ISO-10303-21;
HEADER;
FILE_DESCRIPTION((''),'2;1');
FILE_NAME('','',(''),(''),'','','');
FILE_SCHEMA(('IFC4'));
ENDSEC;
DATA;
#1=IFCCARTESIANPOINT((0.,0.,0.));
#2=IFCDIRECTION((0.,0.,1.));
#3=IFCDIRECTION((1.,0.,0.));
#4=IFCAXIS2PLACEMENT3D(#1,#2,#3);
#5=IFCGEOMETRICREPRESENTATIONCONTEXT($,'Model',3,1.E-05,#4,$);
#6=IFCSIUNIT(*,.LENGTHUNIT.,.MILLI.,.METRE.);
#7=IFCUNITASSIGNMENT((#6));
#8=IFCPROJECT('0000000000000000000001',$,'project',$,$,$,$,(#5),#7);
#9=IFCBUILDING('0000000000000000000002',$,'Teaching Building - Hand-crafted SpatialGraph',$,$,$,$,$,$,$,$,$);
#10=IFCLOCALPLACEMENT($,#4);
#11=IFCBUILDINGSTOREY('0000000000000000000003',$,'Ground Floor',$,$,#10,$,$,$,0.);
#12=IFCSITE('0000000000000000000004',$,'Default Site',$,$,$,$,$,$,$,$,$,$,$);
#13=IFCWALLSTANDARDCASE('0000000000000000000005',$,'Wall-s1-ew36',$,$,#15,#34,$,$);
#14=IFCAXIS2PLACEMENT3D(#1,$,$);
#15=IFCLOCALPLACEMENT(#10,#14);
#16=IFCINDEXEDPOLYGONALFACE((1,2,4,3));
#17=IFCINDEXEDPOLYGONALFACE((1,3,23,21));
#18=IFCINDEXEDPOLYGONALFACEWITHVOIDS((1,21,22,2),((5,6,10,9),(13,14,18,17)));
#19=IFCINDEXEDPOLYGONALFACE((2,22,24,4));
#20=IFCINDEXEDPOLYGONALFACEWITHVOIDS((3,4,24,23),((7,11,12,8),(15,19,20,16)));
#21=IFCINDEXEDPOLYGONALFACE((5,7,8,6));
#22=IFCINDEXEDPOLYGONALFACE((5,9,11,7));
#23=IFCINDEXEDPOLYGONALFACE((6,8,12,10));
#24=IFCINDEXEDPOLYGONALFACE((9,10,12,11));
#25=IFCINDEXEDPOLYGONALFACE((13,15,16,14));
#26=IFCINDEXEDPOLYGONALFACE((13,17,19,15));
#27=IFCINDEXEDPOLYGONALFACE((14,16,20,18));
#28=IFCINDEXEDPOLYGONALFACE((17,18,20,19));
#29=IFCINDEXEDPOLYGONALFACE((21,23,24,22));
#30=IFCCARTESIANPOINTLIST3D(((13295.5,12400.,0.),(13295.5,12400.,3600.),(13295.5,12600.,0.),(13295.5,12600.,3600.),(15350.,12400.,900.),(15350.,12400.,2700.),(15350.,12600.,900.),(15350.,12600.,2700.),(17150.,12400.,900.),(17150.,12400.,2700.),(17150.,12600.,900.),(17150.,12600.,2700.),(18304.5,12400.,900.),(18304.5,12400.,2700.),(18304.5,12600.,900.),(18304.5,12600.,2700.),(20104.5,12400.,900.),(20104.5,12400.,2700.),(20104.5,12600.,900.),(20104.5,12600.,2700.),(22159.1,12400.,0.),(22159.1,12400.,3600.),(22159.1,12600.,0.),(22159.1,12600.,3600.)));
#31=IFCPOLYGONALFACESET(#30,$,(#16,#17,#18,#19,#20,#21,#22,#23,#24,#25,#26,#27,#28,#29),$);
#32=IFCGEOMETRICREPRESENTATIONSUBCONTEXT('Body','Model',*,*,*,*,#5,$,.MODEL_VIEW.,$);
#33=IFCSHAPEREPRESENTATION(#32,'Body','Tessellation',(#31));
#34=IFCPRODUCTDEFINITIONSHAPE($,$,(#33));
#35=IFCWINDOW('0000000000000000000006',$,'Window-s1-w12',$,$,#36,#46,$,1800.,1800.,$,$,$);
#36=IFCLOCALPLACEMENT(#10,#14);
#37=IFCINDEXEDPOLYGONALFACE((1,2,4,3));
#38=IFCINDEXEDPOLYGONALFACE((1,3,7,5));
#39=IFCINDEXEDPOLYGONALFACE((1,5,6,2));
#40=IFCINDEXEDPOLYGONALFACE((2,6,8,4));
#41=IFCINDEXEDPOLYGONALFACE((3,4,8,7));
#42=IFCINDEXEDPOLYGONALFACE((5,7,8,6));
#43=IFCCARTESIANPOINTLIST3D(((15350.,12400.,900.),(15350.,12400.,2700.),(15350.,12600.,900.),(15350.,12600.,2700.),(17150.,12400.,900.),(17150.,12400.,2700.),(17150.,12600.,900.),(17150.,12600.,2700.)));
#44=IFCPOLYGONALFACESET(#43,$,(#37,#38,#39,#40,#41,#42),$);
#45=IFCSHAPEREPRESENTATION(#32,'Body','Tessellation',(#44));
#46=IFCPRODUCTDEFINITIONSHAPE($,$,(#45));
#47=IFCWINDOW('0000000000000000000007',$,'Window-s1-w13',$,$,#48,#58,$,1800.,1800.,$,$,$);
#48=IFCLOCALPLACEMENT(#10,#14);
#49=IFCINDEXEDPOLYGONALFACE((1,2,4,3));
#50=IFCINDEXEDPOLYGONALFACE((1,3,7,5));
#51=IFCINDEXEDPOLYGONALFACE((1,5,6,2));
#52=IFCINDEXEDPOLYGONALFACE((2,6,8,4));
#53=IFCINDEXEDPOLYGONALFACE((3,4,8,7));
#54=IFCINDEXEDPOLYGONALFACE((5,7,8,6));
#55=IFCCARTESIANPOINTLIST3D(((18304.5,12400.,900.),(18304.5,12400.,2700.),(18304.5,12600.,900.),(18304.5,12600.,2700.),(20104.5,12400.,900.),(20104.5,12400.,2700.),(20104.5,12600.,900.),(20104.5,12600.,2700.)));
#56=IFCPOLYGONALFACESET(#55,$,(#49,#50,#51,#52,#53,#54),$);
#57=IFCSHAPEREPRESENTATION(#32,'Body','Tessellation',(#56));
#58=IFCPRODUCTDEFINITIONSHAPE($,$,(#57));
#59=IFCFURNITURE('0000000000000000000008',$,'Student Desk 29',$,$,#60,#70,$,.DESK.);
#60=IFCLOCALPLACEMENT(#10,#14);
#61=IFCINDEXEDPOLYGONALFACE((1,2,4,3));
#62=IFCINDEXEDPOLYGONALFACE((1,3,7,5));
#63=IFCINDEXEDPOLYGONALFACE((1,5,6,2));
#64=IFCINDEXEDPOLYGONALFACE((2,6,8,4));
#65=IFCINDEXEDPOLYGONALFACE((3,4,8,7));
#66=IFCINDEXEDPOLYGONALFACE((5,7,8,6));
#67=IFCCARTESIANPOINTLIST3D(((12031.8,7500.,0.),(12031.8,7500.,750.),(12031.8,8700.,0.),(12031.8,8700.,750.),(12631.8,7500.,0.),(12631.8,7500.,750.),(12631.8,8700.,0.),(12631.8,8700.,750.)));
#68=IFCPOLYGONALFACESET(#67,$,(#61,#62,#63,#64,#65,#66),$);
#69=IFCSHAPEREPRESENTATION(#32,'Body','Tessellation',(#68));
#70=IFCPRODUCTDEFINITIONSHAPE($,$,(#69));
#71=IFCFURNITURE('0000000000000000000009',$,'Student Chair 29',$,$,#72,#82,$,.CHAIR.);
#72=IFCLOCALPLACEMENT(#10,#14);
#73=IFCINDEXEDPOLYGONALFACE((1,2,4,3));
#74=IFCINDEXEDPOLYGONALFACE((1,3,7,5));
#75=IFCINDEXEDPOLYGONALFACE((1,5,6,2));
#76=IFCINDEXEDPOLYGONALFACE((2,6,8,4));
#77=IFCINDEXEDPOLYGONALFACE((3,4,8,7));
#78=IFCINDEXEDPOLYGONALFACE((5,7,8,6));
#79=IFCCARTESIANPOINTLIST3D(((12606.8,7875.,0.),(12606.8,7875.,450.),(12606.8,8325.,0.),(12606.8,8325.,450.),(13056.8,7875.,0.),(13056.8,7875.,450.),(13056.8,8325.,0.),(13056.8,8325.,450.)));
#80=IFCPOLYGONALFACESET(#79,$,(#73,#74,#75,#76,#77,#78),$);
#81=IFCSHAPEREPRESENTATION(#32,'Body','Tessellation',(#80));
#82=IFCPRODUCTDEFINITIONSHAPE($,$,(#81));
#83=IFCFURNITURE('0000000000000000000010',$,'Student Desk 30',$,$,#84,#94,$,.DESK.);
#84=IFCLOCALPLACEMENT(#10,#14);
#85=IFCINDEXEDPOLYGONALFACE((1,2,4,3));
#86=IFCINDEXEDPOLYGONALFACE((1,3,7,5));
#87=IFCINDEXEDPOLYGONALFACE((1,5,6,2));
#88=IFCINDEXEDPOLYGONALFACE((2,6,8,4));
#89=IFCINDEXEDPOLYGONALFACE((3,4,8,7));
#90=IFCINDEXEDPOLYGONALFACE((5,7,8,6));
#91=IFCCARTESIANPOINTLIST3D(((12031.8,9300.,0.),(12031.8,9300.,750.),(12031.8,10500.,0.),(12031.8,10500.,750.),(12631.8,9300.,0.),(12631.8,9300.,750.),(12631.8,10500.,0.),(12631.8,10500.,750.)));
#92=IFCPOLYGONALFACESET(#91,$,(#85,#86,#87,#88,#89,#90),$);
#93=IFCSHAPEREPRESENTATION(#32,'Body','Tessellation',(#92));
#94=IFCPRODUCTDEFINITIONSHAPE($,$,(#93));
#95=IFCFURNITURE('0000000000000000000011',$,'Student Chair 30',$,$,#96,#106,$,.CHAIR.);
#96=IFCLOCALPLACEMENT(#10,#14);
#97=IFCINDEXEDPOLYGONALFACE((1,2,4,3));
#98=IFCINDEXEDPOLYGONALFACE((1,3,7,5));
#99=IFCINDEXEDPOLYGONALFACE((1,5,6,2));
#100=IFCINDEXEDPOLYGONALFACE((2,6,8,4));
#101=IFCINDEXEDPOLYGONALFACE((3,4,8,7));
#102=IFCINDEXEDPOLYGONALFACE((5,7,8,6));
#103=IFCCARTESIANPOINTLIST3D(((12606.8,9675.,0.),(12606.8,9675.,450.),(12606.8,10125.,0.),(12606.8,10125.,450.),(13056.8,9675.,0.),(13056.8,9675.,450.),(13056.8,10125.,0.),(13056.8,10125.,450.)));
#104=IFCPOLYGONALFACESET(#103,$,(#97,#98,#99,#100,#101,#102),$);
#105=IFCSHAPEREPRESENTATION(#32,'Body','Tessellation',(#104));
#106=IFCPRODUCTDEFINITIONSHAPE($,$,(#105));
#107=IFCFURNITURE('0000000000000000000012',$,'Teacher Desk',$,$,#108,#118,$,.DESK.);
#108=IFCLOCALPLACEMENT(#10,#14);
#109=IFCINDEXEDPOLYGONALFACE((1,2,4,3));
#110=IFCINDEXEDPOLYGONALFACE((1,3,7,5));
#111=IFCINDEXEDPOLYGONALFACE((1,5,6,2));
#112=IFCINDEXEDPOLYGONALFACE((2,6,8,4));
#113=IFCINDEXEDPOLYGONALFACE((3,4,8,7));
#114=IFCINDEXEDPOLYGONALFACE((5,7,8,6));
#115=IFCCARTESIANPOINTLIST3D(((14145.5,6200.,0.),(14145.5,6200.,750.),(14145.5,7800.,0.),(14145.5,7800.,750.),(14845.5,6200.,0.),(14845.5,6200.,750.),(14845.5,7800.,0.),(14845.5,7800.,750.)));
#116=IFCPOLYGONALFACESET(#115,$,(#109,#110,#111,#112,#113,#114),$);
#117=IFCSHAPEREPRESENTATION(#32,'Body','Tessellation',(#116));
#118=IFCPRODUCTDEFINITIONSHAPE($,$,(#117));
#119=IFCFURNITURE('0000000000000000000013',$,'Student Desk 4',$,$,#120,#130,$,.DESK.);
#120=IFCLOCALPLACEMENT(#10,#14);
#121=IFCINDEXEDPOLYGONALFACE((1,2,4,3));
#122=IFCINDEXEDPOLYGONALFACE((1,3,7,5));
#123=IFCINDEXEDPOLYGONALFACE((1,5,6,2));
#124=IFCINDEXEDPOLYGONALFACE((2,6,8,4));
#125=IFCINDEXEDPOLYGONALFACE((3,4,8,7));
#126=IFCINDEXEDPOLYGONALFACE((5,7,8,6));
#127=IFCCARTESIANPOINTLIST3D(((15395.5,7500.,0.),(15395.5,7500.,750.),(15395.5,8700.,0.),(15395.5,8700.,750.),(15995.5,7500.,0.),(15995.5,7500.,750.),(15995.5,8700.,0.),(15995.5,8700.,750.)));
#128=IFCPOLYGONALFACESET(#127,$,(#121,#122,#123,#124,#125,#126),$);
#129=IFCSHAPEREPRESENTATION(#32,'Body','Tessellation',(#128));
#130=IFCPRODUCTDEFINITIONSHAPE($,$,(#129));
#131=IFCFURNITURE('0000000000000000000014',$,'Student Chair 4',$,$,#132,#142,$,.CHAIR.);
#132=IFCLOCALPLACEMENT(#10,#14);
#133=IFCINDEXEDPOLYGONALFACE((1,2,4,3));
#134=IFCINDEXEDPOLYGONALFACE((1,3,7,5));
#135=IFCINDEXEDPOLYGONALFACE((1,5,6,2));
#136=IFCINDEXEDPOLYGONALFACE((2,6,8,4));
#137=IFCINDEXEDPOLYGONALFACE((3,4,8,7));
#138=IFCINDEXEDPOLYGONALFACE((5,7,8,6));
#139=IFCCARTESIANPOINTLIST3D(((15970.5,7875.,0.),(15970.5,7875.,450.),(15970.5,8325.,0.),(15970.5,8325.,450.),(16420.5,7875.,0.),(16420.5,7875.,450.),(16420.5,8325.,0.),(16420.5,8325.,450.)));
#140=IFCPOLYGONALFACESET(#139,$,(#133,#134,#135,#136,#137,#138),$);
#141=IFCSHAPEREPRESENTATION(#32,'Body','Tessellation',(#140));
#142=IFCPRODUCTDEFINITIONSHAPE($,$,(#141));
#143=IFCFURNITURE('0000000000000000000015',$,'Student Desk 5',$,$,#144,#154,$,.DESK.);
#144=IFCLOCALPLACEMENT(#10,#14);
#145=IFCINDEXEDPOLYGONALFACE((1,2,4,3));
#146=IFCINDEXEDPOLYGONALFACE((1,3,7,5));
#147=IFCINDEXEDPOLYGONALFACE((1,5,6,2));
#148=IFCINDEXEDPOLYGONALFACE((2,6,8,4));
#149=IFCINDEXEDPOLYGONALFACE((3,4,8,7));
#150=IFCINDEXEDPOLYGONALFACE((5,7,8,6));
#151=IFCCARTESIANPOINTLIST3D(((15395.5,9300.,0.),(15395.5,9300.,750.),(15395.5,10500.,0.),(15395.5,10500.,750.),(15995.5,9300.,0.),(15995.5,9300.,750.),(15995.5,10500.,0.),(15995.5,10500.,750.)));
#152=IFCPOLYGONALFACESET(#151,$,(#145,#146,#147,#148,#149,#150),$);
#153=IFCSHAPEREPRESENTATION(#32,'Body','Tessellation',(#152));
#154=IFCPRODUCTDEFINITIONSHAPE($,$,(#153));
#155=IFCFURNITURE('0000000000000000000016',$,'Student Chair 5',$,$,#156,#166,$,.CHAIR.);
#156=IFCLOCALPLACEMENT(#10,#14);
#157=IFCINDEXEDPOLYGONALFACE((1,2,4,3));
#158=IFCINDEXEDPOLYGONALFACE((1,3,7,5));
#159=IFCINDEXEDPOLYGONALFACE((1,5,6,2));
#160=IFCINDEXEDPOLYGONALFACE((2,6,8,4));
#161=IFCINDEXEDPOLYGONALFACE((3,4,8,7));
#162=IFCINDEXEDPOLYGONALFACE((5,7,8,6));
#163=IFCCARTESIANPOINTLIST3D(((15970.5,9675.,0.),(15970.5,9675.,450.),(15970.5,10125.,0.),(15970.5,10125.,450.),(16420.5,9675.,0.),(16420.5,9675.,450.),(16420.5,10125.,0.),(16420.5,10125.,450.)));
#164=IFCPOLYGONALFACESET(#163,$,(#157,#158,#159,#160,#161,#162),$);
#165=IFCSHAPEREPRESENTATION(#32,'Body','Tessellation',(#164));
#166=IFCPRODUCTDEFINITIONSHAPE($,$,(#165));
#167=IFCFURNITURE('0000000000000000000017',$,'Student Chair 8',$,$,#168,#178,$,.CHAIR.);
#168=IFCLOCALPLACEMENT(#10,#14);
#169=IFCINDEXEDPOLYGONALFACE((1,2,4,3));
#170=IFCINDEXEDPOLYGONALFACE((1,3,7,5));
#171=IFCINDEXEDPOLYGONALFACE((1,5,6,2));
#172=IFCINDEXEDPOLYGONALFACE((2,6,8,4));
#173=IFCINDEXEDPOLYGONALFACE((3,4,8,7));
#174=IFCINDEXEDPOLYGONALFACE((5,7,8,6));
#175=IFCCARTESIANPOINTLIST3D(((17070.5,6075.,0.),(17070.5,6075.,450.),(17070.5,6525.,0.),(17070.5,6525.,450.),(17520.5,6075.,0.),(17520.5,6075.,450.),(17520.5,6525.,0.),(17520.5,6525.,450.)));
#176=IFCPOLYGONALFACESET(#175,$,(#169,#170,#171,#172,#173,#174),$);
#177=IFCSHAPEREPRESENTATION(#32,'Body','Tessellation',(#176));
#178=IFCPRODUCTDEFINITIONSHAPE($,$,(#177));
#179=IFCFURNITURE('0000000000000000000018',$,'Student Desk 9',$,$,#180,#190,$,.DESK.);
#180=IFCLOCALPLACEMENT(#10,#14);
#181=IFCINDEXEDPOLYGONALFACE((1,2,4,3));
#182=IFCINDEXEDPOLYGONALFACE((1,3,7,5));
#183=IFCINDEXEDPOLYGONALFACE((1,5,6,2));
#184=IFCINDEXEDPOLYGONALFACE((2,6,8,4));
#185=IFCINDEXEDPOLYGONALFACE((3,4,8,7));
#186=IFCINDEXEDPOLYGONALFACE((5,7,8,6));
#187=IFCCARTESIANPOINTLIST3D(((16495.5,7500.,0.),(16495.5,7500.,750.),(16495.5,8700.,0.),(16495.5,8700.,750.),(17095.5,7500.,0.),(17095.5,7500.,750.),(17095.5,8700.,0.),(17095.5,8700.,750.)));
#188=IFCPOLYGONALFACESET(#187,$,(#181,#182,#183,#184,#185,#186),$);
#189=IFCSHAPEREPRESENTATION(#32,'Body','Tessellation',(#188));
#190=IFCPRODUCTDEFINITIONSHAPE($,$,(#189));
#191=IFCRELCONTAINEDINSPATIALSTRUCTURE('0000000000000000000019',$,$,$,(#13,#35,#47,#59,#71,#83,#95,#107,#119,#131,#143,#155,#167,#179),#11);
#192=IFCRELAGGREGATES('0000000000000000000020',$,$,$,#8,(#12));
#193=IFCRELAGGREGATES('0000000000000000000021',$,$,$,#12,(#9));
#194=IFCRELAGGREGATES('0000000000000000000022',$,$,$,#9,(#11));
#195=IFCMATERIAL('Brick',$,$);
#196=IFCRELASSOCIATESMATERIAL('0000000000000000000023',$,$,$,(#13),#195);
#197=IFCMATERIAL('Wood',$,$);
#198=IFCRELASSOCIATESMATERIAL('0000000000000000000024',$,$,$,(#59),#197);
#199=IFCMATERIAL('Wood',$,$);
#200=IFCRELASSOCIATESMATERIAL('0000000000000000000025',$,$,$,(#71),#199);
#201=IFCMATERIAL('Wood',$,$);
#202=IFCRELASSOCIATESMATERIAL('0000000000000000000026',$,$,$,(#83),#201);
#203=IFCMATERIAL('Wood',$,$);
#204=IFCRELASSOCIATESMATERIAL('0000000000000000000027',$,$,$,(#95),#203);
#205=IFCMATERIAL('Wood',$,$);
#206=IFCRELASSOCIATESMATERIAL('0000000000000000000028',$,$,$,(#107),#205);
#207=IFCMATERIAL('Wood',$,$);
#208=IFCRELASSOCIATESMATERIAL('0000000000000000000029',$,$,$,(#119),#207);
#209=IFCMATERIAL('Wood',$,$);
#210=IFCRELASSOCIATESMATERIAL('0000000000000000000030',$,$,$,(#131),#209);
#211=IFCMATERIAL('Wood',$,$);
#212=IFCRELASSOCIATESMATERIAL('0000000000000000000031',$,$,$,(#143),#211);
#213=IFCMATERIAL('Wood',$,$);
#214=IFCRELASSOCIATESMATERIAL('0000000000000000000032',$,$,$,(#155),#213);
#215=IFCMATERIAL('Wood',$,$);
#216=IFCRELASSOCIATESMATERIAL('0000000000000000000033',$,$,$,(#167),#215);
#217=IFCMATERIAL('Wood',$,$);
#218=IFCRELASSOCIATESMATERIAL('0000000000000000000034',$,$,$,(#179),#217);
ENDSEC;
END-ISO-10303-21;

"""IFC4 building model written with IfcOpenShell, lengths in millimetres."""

from ifc_helpers import new_model, si_unit, frame, frame_2d, origin_with_axes, origin_2d, place, context, subcontext, project, spatial, rectangle, extrude, material, element, fill, save


model = new_model("IFC4")

# Units and contexts
model_context = context("Model", 3, precision=1e-05, world=origin_with_axes())
body_context = subcontext(model_context, "Body", "Model", "MODEL_VIEW")
ifc_project = project(units=[si_unit("LENGTHUNIT", "METRE", prefix="MILLI")], contexts=[model_context])

# Site, building, storey
site = spatial("IfcSite", under=ifc_project, Name="Default Site")
building = spatial("IfcBuilding", under=site, Name="Teaching Building - Hand-crafted SpatialGraph")
storey_placement = place(None, origin_with_axes())
storey = spatial("IfcBuildingStorey", under=building, at=storey_placement, Name="Ground Floor", Elevation=0.0)

# Wall, openings, windows
ifc_material_1 = material(Name="Brick")
wall_placement = place(storey_placement, frame((13295.5, 12500.0, 0.0), z_axis=(0.0, 0.0, 1.0), x_axis=(1.0, 0.0, 0.0)))
wall = element("IfcWallStandardCase", 1, at=wall_placement, inside=storey, material=ifc_material_1, Name="Wall-s1-ew36", context=body_context, shape_type="SweptSolid", body=[
    extrude(rectangle(XDim=8863.6, YDim=200.0, at=frame_2d((4431.8, 0.0))), origin_with_axes(), (0.0, 0.0, 1.0), 3600.0),
])
opening_1_placement = place(wall_placement, frame((2054.5, 0.0, 900.0), z_axis=(0.0, 0.0, 1.0), x_axis=(1.0, 0.0, 0.0)))
opening_1 = element("IfcOpeningElement", 2, at=opening_1_placement, cuts=wall, context=body_context, shape_type="SweptSolid", body=[
    extrude(rectangle(XDim=1800.0, YDim=400.0, at=frame_2d((900.0, 0.0))), origin_with_axes(), (0.0, 0.0, 1.0), 1800.0),
])
opening_2_placement = place(wall_placement, frame((5009.1, 0.0, 900.0), z_axis=(0.0, 0.0, 1.0), x_axis=(1.0, 0.0, 0.0)))
opening_2 = element("IfcOpeningElement", 3, at=opening_2_placement, cuts=wall, context=body_context, shape_type="SweptSolid", body=[
    extrude(rectangle(XDim=1800.0, YDim=400.0, at=frame_2d((900.0, 0.0))), origin_with_axes(), (0.0, 0.0, 1.0), 1800.0),
])
window_1_placement = place(storey_placement, frame((15350.0, 12500.0, 900.0), z_axis=(0.0, 0.0, 1.0), x_axis=(1.0, 0.0, 0.0)))
window_1 = element("IfcWindow", 4, at=window_1_placement, inside=storey, Name="Window-s1-w12", OverallHeight=1800.0, OverallWidth=1800.0, context=body_context, shape_type="SweptSolid", body=[
    extrude(rectangle(XDim=1800.0, YDim=200.0, at=frame_2d((900.0, 0.0))), origin_with_axes(), (0.0, 0.0, 1.0), 1800.0),
])
fill(opening_1, window_1)
window_2_placement = place(storey_placement, frame((18304.5, 12500.0, 900.0), z_axis=(0.0, 0.0, 1.0), x_axis=(1.0, 0.0, 0.0)))
window_2 = element("IfcWindow", 5, at=window_2_placement, inside=storey, Name="Window-s1-w13", OverallHeight=1800.0, OverallWidth=1800.0, context=body_context, shape_type="SweptSolid", body=[
    extrude(rectangle(XDim=1800.0, YDim=200.0, at=frame_2d((900.0, 0.0))), origin_with_axes(), (0.0, 0.0, 1.0), 1800.0),
])
fill(opening_2, window_2)

# Furniture
ifc_material_2 = material(Name="Wood")
furniture_1_placement = place(storey_placement, frame((12331.8, 8100.0, 0.0), z_axis=(0.0, 0.0, 1.0), x_axis=(0.0, 1.0, 0.0)))
element("IfcFurniture", 6, at=furniture_1_placement, inside=storey, material=ifc_material_2, Name="Student Desk 29", PredefinedType="DESK", context=body_context, shape_type="SweptSolid", body=[
    extrude(rectangle(XDim=1200.0, YDim=600.0, at=origin_2d()), origin_with_axes(), (0.0, 0.0, 1.0), 750.0),
])
ifc_material_3 = material(Name="Wood")
furniture_2_placement = place(storey_placement, frame((12831.8, 8100.0, 0.0), z_axis=(0.0, 0.0, 1.0), x_axis=(1.0, 0.0, 0.0)))
element("IfcFurniture", 7, at=furniture_2_placement, inside=storey, material=ifc_material_3, Name="Student Chair 29", PredefinedType="CHAIR", context=body_context, shape_type="SweptSolid", body=[
    extrude(rectangle(XDim=450.0, YDim=450.0, at=origin_2d()), origin_with_axes(), (0.0, 0.0, 1.0), 450.0),
])
ifc_material_4 = material(Name="Wood")
furniture_3_placement = place(storey_placement, frame((12331.8, 9900.0, 0.0), z_axis=(0.0, 0.0, 1.0), x_axis=(0.0, 1.0, 0.0)))
element("IfcFurniture", 8, at=furniture_3_placement, inside=storey, material=ifc_material_4, Name="Student Desk 30", PredefinedType="DESK", context=body_context, shape_type="SweptSolid", body=[
    extrude(rectangle(XDim=1200.0, YDim=600.0, at=origin_2d()), origin_with_axes(), (0.0, 0.0, 1.0), 750.0),
])
ifc_material_5 = material(Name="Wood")
furniture_4_placement = place(storey_placement, frame((12831.8, 9900.0, 0.0), z_axis=(0.0, 0.0, 1.0), x_axis=(1.0, 0.0, 0.0)))
element("IfcFurniture", 9, at=furniture_4_placement, inside=storey, material=ifc_material_5, Name="Student Chair 30", PredefinedType="CHAIR", context=body_context, shape_type="SweptSolid", body=[
    extrude(rectangle(XDim=450.0, YDim=450.0, at=origin_2d()), origin_with_axes(), (0.0, 0.0, 1.0), 450.0),
])
ifc_material_6 = material(Name="Wood")
furniture_5_placement = place(storey_placement, frame((14495.5, 7000.0, 0.0), z_axis=(0.0, 0.0, 1.0), x_axis=(0.0, 1.0, 0.0)))
element("IfcFurniture", 10, at=furniture_5_placement, inside=storey, material=ifc_material_6, Name="Teacher Desk", PredefinedType="DESK", context=body_context, shape_type="SweptSolid", body=[
    extrude(rectangle(XDim=1600.0, YDim=700.0, at=origin_2d()), origin_with_axes(), (0.0, 0.0, 1.0), 750.0),
])
ifc_material_7 = material(Name="Wood")
furniture_6_placement = place(storey_placement, frame((15695.5, 8100.0, 0.0), z_axis=(0.0, 0.0, 1.0), x_axis=(0.0, 1.0, 0.0)))
element("IfcFurniture", 11, at=furniture_6_placement, inside=storey, material=ifc_material_7, Name="Student Desk 4", PredefinedType="DESK", context=body_context, shape_type="SweptSolid", body=[
    extrude(rectangle(XDim=1200.0, YDim=600.0, at=origin_2d()), origin_with_axes(), (0.0, 0.0, 1.0), 750.0),
])
ifc_material_8 = material(Name="Wood")
furniture_7_placement = place(storey_placement, frame((16195.5, 8100.0, 0.0), z_axis=(0.0, 0.0, 1.0), x_axis=(1.0, 0.0, 0.0)))
element("IfcFurniture", 12, at=furniture_7_placement, inside=storey, material=ifc_material_8, Name="Student Chair 4", PredefinedType="CHAIR", context=body_context, shape_type="SweptSolid", body=[
    extrude(rectangle(XDim=450.0, YDim=450.0, at=origin_2d()), origin_with_axes(), (0.0, 0.0, 1.0), 450.0),
])
ifc_material_9 = material(Name="Wood")
furniture_8_placement = place(storey_placement, frame((15695.5, 9900.0, 0.0), z_axis=(0.0, 0.0, 1.0), x_axis=(0.0, 1.0, 0.0)))
element("IfcFurniture", 13, at=furniture_8_placement, inside=storey, material=ifc_material_9, Name="Student Desk 5", PredefinedType="DESK", context=body_context, shape_type="SweptSolid", body=[
    extrude(rectangle(XDim=1200.0, YDim=600.0, at=origin_2d()), origin_with_axes(), (0.0, 0.0, 1.0), 750.0),
])
ifc_material_10 = material(Name="Wood")
furniture_9_placement = place(storey_placement, frame((16195.5, 9900.0, 0.0), z_axis=(0.0, 0.0, 1.0), x_axis=(1.0, 0.0, 0.0)))
element("IfcFurniture", 14, at=furniture_9_placement, inside=storey, material=ifc_material_10, Name="Student Chair 5", PredefinedType="CHAIR", context=body_context, shape_type="SweptSolid", body=[
    extrude(rectangle(XDim=450.0, YDim=450.0, at=origin_2d()), origin_with_axes(), (0.0, 0.0, 1.0), 450.0),
])
ifc_material_11 = material(Name="Wood")
furniture_10_placement = place(storey_placement, frame((17295.5, 6300.0, 0.0), z_axis=(0.0, 0.0, 1.0), x_axis=(1.0, 0.0, 0.0)))
element("IfcFurniture", 15, at=furniture_10_placement, inside=storey, material=ifc_material_11, Name="Student Chair 8", PredefinedType="CHAIR", context=body_context, shape_type="SweptSolid", body=[
    extrude(rectangle(XDim=450.0, YDim=450.0, at=origin_2d()), origin_with_axes(), (0.0, 0.0, 1.0), 450.0),
])
ifc_material_12 = material(Name="Wood")
furniture_11_placement = place(storey_placement, frame((16795.5, 8100.0, 0.0), z_axis=(0.0, 0.0, 1.0), x_axis=(0.0, 1.0, 0.0)))
element("IfcFurniture", 16, at=furniture_11_placement, inside=storey, material=ifc_material_12, Name="Student Desk 9", PredefinedType="DESK", context=body_context, shape_type="SweptSolid", body=[
    extrude(rectangle(XDim=1200.0, YDim=600.0, at=origin_2d()), origin_with_axes(), (0.0, 0.0, 1.0), 750.0),
])

save(model, "model.ifc")
